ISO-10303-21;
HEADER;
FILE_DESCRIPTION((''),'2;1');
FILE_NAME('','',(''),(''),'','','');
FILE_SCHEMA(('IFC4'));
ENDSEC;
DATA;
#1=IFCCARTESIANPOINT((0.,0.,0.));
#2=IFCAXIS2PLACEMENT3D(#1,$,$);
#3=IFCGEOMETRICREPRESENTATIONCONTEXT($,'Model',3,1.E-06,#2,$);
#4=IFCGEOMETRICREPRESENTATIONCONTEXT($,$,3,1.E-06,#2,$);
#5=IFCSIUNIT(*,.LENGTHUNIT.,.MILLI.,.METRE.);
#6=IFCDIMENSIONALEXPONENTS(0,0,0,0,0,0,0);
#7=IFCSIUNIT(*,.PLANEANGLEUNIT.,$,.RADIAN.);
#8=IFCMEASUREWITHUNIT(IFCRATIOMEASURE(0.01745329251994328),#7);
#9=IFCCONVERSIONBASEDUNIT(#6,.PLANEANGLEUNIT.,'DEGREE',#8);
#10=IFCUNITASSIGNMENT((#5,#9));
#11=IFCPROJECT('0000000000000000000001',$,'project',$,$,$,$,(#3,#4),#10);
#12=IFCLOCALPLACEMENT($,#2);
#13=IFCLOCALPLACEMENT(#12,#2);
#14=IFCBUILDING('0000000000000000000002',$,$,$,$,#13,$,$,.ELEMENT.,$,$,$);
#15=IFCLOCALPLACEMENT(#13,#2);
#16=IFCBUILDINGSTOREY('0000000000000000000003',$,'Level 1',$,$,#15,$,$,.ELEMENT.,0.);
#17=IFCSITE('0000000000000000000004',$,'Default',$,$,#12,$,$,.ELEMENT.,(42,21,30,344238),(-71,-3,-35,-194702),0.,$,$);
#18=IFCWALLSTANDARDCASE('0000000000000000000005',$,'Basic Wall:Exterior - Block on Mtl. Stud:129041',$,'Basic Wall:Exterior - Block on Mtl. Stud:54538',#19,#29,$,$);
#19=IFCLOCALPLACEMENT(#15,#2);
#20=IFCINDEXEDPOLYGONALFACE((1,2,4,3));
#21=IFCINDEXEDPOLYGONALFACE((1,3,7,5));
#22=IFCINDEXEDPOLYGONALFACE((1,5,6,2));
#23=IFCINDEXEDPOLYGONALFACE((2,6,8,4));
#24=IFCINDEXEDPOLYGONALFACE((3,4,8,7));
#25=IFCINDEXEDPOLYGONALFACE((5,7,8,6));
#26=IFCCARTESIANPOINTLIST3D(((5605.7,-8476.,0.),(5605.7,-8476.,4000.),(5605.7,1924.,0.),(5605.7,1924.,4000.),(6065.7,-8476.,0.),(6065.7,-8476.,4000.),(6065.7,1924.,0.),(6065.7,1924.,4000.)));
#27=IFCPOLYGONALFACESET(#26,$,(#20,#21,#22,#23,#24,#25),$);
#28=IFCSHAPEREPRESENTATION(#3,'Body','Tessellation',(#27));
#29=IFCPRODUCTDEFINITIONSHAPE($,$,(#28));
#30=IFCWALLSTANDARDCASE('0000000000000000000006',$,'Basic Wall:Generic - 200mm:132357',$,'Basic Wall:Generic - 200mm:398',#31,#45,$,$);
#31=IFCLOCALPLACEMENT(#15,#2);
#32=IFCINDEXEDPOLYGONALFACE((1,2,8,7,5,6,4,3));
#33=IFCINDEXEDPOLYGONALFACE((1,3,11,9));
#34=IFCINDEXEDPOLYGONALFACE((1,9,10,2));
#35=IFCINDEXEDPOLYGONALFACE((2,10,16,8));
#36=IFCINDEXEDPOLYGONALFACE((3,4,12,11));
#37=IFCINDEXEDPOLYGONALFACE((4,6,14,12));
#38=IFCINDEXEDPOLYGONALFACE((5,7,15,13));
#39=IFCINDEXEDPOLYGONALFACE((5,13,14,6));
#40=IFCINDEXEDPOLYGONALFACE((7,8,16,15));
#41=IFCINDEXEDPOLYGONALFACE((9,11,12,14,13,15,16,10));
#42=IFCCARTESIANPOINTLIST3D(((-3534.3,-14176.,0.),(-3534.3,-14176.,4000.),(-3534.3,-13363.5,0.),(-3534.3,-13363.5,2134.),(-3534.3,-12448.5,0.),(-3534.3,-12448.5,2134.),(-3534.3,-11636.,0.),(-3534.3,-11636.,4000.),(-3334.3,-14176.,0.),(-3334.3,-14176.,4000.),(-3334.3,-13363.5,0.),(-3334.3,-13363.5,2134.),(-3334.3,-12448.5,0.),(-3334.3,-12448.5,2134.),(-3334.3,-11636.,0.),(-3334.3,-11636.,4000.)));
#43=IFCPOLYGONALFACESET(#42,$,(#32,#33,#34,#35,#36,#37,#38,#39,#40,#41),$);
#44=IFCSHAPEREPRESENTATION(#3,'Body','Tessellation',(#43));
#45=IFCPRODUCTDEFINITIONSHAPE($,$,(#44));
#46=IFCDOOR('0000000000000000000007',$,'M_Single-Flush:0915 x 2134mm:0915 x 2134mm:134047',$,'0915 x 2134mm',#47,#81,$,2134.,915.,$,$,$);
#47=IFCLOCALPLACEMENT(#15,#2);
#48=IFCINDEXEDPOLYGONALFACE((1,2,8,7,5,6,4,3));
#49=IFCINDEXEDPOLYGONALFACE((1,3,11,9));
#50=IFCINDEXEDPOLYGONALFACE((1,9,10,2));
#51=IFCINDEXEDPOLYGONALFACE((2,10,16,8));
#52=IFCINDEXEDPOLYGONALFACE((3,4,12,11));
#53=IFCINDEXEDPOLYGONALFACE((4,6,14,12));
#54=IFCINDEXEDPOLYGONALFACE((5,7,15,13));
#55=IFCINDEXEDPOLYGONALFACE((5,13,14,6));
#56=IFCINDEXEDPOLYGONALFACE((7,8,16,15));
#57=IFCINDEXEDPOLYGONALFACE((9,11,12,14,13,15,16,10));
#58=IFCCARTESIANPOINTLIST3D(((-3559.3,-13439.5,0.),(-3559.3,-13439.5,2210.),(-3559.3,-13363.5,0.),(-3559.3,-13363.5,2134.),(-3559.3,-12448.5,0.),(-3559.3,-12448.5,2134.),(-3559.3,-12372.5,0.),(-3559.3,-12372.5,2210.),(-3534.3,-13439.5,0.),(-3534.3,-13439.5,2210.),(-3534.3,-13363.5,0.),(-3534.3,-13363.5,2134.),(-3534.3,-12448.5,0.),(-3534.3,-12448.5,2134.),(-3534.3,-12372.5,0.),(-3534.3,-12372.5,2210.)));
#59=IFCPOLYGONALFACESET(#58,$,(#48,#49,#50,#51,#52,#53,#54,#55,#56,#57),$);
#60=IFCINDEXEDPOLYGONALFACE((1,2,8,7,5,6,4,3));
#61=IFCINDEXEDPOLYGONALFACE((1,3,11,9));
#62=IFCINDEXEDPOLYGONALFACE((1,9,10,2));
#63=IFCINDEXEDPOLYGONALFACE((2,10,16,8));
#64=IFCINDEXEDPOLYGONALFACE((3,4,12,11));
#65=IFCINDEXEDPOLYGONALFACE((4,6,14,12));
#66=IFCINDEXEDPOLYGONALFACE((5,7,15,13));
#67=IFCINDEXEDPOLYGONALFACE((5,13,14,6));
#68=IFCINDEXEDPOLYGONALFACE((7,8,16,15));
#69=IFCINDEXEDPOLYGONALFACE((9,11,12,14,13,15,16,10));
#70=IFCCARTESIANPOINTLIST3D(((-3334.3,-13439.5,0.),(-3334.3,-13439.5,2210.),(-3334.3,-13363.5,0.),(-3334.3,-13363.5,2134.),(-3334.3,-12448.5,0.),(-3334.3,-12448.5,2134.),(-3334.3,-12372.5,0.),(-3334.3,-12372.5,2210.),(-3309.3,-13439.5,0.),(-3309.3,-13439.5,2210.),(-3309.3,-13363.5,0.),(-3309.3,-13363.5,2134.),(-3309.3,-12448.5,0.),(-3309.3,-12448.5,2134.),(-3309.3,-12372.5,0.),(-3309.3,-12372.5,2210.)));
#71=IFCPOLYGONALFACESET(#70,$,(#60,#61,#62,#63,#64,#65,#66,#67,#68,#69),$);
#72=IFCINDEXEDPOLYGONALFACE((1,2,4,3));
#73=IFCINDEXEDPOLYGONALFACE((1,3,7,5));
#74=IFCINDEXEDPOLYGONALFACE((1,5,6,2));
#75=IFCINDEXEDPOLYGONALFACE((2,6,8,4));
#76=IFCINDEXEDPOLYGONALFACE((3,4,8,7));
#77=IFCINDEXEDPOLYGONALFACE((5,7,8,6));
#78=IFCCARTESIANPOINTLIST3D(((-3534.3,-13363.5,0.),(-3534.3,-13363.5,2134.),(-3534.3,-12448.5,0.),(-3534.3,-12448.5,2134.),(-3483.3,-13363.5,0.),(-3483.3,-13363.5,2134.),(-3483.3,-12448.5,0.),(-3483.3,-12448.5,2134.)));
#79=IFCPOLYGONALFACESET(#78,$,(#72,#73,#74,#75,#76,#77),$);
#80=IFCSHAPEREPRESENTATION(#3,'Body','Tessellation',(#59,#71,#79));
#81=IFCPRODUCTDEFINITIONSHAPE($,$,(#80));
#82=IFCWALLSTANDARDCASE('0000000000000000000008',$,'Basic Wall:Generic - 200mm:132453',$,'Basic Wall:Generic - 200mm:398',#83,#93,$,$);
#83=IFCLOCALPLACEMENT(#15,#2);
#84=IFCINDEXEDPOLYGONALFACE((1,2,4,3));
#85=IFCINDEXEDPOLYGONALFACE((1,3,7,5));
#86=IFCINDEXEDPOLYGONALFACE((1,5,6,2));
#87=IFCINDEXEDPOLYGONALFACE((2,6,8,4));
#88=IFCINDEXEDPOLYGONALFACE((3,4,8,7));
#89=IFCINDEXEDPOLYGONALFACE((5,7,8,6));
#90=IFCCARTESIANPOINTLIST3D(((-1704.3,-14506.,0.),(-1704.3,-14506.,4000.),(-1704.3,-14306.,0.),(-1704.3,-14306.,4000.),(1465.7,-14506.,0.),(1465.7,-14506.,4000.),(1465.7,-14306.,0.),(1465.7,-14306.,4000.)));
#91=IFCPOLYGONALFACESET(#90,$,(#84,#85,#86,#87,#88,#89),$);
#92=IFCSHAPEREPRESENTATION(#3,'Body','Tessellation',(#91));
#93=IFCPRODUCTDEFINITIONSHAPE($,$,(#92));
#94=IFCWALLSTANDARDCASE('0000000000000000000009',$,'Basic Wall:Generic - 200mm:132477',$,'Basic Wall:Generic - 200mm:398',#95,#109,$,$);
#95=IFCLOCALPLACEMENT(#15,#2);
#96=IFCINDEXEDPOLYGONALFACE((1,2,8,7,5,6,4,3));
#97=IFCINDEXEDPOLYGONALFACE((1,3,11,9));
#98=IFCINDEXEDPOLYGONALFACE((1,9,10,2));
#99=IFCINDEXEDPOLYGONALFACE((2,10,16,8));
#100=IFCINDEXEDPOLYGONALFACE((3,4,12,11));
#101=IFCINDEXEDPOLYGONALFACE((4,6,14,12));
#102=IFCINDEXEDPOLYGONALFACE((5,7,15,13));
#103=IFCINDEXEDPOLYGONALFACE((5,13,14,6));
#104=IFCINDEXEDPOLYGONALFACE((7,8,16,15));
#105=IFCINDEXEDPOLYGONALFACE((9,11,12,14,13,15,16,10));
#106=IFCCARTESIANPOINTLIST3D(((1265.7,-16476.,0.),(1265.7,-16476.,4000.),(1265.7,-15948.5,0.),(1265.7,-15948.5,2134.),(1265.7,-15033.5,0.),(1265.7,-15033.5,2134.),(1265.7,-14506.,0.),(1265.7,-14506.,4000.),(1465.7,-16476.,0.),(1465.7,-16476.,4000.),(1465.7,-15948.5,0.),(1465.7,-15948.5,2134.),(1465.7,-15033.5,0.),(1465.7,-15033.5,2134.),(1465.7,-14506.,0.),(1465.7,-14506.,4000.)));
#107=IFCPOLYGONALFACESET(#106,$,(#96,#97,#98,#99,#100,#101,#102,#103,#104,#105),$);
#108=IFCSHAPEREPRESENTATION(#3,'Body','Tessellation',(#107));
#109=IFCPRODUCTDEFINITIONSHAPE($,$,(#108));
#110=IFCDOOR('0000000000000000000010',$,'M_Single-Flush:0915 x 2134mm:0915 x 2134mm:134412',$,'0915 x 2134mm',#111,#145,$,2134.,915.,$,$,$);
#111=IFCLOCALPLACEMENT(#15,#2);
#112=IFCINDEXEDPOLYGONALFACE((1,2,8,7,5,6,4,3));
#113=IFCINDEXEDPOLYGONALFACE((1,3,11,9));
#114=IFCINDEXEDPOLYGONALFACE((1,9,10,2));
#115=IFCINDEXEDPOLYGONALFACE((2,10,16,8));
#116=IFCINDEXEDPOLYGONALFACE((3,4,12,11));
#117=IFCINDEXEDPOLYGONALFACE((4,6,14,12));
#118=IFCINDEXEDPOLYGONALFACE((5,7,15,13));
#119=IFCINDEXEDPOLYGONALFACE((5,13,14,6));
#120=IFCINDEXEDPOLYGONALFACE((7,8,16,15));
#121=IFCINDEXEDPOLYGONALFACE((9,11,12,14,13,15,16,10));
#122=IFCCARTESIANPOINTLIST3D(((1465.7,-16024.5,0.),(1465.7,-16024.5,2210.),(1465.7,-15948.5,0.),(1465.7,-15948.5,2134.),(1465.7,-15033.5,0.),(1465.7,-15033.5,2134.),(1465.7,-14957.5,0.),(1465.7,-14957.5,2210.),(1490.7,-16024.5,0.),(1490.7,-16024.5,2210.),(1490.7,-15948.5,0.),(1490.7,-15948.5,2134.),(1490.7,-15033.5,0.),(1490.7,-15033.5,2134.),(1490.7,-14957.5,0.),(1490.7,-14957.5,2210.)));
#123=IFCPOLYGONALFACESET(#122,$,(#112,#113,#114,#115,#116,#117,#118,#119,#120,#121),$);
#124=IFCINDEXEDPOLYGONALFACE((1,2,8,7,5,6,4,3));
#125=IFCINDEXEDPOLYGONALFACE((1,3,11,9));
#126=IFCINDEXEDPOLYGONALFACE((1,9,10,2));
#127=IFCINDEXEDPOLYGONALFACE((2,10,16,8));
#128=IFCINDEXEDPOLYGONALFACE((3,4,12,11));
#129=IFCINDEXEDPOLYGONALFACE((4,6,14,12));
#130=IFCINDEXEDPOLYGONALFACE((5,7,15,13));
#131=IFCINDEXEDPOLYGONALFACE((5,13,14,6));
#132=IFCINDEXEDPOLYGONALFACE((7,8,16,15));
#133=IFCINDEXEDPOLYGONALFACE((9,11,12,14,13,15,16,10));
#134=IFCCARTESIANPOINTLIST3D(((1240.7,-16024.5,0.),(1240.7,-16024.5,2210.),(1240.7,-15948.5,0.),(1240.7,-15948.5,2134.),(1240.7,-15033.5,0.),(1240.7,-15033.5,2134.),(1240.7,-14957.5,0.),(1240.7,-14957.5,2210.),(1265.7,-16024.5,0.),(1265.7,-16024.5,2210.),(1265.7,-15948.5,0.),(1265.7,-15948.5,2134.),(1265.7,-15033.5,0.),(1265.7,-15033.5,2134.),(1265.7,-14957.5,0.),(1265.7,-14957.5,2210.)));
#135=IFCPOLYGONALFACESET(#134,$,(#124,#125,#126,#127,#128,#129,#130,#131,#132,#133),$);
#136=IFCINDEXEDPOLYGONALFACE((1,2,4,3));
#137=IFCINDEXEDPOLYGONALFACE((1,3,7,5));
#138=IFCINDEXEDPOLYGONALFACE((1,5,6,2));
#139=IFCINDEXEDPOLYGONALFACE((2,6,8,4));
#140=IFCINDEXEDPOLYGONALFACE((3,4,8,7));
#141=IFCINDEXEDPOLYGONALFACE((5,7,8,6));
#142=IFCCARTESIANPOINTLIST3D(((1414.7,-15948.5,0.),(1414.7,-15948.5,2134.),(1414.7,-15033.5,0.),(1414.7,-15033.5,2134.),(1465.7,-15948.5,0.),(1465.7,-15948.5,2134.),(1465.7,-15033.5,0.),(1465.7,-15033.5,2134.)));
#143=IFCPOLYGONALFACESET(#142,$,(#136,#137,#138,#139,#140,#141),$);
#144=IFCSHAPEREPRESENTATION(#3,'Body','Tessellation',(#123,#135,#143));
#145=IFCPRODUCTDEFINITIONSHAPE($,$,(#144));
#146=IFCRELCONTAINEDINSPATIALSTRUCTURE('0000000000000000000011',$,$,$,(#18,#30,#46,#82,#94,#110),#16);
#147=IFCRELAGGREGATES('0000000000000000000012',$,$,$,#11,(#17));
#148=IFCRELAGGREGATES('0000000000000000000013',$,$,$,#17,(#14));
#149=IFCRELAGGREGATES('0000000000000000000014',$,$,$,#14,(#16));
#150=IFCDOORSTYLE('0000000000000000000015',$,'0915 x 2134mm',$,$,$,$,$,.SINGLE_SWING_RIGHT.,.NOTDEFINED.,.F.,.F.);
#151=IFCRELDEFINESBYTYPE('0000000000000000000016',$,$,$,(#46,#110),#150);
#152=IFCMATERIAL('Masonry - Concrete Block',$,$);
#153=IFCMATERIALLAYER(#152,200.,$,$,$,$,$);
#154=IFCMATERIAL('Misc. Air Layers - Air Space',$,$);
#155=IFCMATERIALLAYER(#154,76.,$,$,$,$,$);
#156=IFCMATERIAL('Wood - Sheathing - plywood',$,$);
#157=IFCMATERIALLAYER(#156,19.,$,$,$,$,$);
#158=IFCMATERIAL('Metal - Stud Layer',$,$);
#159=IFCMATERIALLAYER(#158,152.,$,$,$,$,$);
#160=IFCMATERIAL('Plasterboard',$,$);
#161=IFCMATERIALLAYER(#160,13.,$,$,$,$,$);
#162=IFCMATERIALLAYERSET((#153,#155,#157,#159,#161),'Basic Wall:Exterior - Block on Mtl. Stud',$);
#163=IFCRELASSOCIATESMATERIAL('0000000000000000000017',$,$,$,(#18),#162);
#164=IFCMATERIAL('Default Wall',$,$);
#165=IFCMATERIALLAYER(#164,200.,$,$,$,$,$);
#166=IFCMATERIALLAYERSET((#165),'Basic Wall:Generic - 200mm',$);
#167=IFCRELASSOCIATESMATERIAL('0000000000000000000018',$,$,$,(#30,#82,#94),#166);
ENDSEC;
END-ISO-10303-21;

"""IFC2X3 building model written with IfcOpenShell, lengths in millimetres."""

from ifc_helpers import new_model, entity, si_unit, converted_unit, frame, frame_2d, origin, origin_2d_with_axis, place, context, project, spatial, polyline, rectangle, outline, extrude, source, transform, mapped, material, layer, layer_set, layer_usage, type_object, type_shapes, element, fill, save


model = new_model("IFC2X3")

# Units and contexts
model_context = context("Model", 3, precision=1e-06, world=origin())
context_of_model = context(None, 3, precision=1e-06, world=origin())
ifc_project = project(units=[si_unit("LENGTHUNIT", "METRE", prefix="MILLI"), converted_unit("PLANEANGLEUNIT", "DEGREE", entity("IfcRatioMeasure", 0.01745329251994328), si_unit("PLANEANGLEUNIT", "RADIAN"), dimensions=[0, 0, 0, 0, 0, 0, 0])], contexts=[model_context, context_of_model])

# Site, building, storey
site_placement = place(None, origin())
site = spatial("IfcSite", under=ifc_project, at=site_placement, Name="Default", CompositionType="ELEMENT", RefLatitude=(42, 21, 30, 344238), RefLongitude=(-71, -3, -35, -194702), RefElevation=0.0)
building_placement = place(site_placement, origin())
building = spatial("IfcBuilding", under=site, at=building_placement, CompositionType="ELEMENT")
storey_placement = place(building_placement, origin())
storey = spatial("IfcBuildingStorey", under=building, at=storey_placement, Name="Level 1", CompositionType="ELEMENT", Elevation=0.0)

# Shared definitions
ifc_material_1 = material(Name="Masonry - Concrete Block")
ifc_layer_1 = layer(ifc_material_1, 200.0)
ifc_material_2 = material(Name="Misc. Air Layers - Air Space")
ifc_layer_2 = layer(ifc_material_2, 76.0)
ifc_material_3 = material(Name="Wood - Sheathing - plywood")
ifc_layer_3 = layer(ifc_material_3, 19.0)
ifc_material_4 = material(Name="Metal - Stud Layer")
ifc_layer_4 = layer(ifc_material_4, 152.0)
ifc_material_5 = material(Name="Plasterboard")
ifc_layer_5 = layer(ifc_material_5, 13.0)
ifc_layer_set_1 = layer_set([ifc_layer_1, ifc_layer_2, ifc_layer_3, ifc_layer_4, ifc_layer_5], Name="Basic Wall:Exterior - Block on Mtl. Stud")

# Wall
ifc_layer_usage_1 = layer_usage(ifc_layer_set_1, "AXIS2", "NEGATIVE", 230.0)
wall_1_placement = place(storey_placement, frame((5835.7, -8476.0, 0.0), z_axis=(0.0, 0.0, 1.0), x_axis=(0.0, 1.0, 0.0)))
element("IfcWallStandardCase", 1, at=wall_1_placement, inside=storey, material=ifc_layer_usage_1, Name="Basic Wall:Exterior - Block on Mtl. Stud:129041", ObjectType="Basic Wall:Exterior - Block on Mtl. Stud:54538", context=model_context, shape_type="SweptSolid", body=[
    extrude(rectangle(XDim=10400.0, YDim=460.0, at=frame_2d((5200.0, 0.0), x_axis=(-1.0, 0.0))), origin(), (0.0, 0.0, 1.0), 4000.0),
])

# Wall, opening, door
ifc_material_6 = material(Name="Default Wall")
ifc_layer_6 = layer(ifc_material_6, 200.0)
ifc_layer_set_2 = layer_set([ifc_layer_6], Name="Basic Wall:Generic - 200mm")
ifc_layer_usage_2 = layer_usage(ifc_layer_set_2, "AXIS2", "NEGATIVE", 100.0)
wall_2_placement = place(storey_placement, frame((-3434.3, -11636.0, 0.0), z_axis=(0.0, 0.0, 1.0), x_axis=(0.0, -1.0, 0.0)))
wall_2 = element("IfcWallStandardCase", 2, at=wall_2_placement, inside=storey, material=ifc_layer_usage_2, Name="Basic Wall:Generic - 200mm:132357", ObjectType="Basic Wall:Generic - 200mm:398", context=model_context, shape_type="SweptSolid", body=[
    extrude(rectangle(XDim=2540.0, YDim=200.0, at=frame_2d((1270.0, 0.0), x_axis=(-1.0, 0.0))), origin(), (0.0, 0.0, 1.0), 4000.0),
])
opening_1_placement = place(wall_2_placement, frame((1727.5, 100.0, 0.0)))
opening_1 = element("IfcOpeningElement", 3, at=opening_1_placement, cuts=wall_2, ObjectType="Opening", context=model_context, shape_type="SweptSolid", body=[
    extrude(rectangle(XDim=915.0, YDim=2134.0, at=frame_2d((1067.0, 457.5), x_axis=(0.0, 1.0))), frame((0.0, 0.0, 0.0), z_axis=(0.0, -1.0, 0.0), x_axis=(0.0, 0.0, 1.0)), (0.0, 0.0, 1.0), 200.0),
])
door_style_1 = type_object("IfcDoorStyle", Name="0915 x 2134mm", ConstructionType="NOTDEFINED", OperationType="SINGLE_SWING_RIGHT", ParameterTakesPrecedence=False, Sizeable=False)
shared_shape_1 = source(origin(), model_context, "Body", "SweptSolid", [
    extrude(outline(polyline([(-533.5, -1124.0), (533.5, -1124.0), (533.5, 1086.0), (457.5, 1086.0), (457.5, -1048.0), (-457.5, -1048.0), (-457.5, 1086.0), (-533.5, 1086.0), (-533.5, -1124.0)])), frame((457.5, 200.0, 1086.0), z_axis=(0.0, 1.0, 0.0), x_axis=(1.0, 0.0, 0.0)), (0.0, 0.0, 1.0), 25.0),
    extrude(outline(polyline([(-1124.0, -533.5), (1086.0, -533.5), (1086.0, -457.5), (-1048.0, -457.5), (-1048.0, 457.5), (1086.0, 457.5), (1086.0, 533.5), (-1124.0, 533.5), (-1124.0, -533.5)])), frame((457.5, -25.0, 1086.0), z_axis=(0.0, 1.0, 0.0), x_axis=(0.0, 0.0, -1.0)), (0.0, 0.0, 1.0), 25.0),
    extrude(rectangle(XDim=51.0, YDim=915.0, at=origin_2d_with_axis()), frame((457.5, 174.5, 0.0), z_axis=(0.0, 0.0, 1.0), x_axis=(0.0, 1.0, 0.0)), (0.0, 0.0, 1.0), 2134.0),
])
type_shapes(door_style_1, [shared_shape_1])
door_1_placement = place(opening_1_placement, frame((0.0, 0.0, 0.0), z_axis=(0.0, 0.0, 1.0), x_axis=(-1.0, 0.0, 0.0)))
door_1 = element("IfcDoor", 4, at=door_1_placement, inside=storey, type_object=door_style_1, Name="M_Single-Flush:0915 x 2134mm:0915 x 2134mm:134047", ObjectType="0915 x 2134mm", OverallHeight=2134.0, OverallWidth=915.0, context=model_context, shape_type="MappedRepresentation", body=[
    mapped(shared_shape_1, transform((0.0, 0.0, 0.0), scale=1.0)),
])
fill(opening_1, door_1)

# Wall
ifc_layer_usage_3 = layer_usage(ifc_layer_set_2, "AXIS2", "NEGATIVE", 100.0)
wall_3_placement = place(storey_placement, frame((-1704.3, -14406.0, 0.0)))
element("IfcWallStandardCase", 5, at=wall_3_placement, inside=storey, material=ifc_layer_usage_3, Name="Basic Wall:Generic - 200mm:132453", ObjectType="Basic Wall:Generic - 200mm:398", context=model_context, shape_type="SweptSolid", body=[
    extrude(rectangle(XDim=3170.0, YDim=200.0, at=frame_2d((1585.0, 0.0), x_axis=(-1.0, 0.0))), origin(), (0.0, 0.0, 1.0), 4000.0),
])

# Wall, opening, door
ifc_layer_usage_4 = layer_usage(ifc_layer_set_2, "AXIS2", "NEGATIVE", 100.0)
wall_4_placement = place(storey_placement, frame((1365.7, -14506.0, 0.0), z_axis=(0.0, 0.0, 1.0), x_axis=(0.0, -1.0, 0.0)))
wall_4 = element("IfcWallStandardCase", 6, at=wall_4_placement, inside=storey, material=ifc_layer_usage_4, Name="Basic Wall:Generic - 200mm:132477", ObjectType="Basic Wall:Generic - 200mm:398", context=model_context, shape_type="SweptSolid", body=[
    extrude(rectangle(XDim=1970.0, YDim=200.0, at=frame_2d((985.0, 0.0), x_axis=(-1.0, 0.0))), origin(), (0.0, 0.0, 1.0), 4000.0),
])
opening_2_placement = place(wall_4_placement, frame((527.5, -100.0, 0.0)))
opening_2 = element("IfcOpeningElement", 7, at=opening_2_placement, cuts=wall_4, ObjectType="Opening", context=model_context, shape_type="SweptSolid", body=[
    extrude(rectangle(XDim=915.0, YDim=2134.0, at=frame_2d((1067.0, 457.5), x_axis=(0.0, 1.0))), frame((0.0, 0.0, 0.0), z_axis=(0.0, 1.0, 0.0), x_axis=(0.0, 0.0, 1.0)), (0.0, 0.0, 1.0), 200.0),
])
door_2_placement = place(opening_2_placement, origin())
door_2 = element("IfcDoor", 8, at=door_2_placement, inside=storey, type_object=door_style_1, Name="M_Single-Flush:0915 x 2134mm:0915 x 2134mm:134412", ObjectType="0915 x 2134mm", OverallHeight=2134.0, OverallWidth=915.0, context=model_context, shape_type="MappedRepresentation", body=[
    mapped(shared_shape_1, transform((0.0, 0.0, 0.0), scale=1.0)),
])
fill(opening_2, door_2)

save(model, "model.ifc")
